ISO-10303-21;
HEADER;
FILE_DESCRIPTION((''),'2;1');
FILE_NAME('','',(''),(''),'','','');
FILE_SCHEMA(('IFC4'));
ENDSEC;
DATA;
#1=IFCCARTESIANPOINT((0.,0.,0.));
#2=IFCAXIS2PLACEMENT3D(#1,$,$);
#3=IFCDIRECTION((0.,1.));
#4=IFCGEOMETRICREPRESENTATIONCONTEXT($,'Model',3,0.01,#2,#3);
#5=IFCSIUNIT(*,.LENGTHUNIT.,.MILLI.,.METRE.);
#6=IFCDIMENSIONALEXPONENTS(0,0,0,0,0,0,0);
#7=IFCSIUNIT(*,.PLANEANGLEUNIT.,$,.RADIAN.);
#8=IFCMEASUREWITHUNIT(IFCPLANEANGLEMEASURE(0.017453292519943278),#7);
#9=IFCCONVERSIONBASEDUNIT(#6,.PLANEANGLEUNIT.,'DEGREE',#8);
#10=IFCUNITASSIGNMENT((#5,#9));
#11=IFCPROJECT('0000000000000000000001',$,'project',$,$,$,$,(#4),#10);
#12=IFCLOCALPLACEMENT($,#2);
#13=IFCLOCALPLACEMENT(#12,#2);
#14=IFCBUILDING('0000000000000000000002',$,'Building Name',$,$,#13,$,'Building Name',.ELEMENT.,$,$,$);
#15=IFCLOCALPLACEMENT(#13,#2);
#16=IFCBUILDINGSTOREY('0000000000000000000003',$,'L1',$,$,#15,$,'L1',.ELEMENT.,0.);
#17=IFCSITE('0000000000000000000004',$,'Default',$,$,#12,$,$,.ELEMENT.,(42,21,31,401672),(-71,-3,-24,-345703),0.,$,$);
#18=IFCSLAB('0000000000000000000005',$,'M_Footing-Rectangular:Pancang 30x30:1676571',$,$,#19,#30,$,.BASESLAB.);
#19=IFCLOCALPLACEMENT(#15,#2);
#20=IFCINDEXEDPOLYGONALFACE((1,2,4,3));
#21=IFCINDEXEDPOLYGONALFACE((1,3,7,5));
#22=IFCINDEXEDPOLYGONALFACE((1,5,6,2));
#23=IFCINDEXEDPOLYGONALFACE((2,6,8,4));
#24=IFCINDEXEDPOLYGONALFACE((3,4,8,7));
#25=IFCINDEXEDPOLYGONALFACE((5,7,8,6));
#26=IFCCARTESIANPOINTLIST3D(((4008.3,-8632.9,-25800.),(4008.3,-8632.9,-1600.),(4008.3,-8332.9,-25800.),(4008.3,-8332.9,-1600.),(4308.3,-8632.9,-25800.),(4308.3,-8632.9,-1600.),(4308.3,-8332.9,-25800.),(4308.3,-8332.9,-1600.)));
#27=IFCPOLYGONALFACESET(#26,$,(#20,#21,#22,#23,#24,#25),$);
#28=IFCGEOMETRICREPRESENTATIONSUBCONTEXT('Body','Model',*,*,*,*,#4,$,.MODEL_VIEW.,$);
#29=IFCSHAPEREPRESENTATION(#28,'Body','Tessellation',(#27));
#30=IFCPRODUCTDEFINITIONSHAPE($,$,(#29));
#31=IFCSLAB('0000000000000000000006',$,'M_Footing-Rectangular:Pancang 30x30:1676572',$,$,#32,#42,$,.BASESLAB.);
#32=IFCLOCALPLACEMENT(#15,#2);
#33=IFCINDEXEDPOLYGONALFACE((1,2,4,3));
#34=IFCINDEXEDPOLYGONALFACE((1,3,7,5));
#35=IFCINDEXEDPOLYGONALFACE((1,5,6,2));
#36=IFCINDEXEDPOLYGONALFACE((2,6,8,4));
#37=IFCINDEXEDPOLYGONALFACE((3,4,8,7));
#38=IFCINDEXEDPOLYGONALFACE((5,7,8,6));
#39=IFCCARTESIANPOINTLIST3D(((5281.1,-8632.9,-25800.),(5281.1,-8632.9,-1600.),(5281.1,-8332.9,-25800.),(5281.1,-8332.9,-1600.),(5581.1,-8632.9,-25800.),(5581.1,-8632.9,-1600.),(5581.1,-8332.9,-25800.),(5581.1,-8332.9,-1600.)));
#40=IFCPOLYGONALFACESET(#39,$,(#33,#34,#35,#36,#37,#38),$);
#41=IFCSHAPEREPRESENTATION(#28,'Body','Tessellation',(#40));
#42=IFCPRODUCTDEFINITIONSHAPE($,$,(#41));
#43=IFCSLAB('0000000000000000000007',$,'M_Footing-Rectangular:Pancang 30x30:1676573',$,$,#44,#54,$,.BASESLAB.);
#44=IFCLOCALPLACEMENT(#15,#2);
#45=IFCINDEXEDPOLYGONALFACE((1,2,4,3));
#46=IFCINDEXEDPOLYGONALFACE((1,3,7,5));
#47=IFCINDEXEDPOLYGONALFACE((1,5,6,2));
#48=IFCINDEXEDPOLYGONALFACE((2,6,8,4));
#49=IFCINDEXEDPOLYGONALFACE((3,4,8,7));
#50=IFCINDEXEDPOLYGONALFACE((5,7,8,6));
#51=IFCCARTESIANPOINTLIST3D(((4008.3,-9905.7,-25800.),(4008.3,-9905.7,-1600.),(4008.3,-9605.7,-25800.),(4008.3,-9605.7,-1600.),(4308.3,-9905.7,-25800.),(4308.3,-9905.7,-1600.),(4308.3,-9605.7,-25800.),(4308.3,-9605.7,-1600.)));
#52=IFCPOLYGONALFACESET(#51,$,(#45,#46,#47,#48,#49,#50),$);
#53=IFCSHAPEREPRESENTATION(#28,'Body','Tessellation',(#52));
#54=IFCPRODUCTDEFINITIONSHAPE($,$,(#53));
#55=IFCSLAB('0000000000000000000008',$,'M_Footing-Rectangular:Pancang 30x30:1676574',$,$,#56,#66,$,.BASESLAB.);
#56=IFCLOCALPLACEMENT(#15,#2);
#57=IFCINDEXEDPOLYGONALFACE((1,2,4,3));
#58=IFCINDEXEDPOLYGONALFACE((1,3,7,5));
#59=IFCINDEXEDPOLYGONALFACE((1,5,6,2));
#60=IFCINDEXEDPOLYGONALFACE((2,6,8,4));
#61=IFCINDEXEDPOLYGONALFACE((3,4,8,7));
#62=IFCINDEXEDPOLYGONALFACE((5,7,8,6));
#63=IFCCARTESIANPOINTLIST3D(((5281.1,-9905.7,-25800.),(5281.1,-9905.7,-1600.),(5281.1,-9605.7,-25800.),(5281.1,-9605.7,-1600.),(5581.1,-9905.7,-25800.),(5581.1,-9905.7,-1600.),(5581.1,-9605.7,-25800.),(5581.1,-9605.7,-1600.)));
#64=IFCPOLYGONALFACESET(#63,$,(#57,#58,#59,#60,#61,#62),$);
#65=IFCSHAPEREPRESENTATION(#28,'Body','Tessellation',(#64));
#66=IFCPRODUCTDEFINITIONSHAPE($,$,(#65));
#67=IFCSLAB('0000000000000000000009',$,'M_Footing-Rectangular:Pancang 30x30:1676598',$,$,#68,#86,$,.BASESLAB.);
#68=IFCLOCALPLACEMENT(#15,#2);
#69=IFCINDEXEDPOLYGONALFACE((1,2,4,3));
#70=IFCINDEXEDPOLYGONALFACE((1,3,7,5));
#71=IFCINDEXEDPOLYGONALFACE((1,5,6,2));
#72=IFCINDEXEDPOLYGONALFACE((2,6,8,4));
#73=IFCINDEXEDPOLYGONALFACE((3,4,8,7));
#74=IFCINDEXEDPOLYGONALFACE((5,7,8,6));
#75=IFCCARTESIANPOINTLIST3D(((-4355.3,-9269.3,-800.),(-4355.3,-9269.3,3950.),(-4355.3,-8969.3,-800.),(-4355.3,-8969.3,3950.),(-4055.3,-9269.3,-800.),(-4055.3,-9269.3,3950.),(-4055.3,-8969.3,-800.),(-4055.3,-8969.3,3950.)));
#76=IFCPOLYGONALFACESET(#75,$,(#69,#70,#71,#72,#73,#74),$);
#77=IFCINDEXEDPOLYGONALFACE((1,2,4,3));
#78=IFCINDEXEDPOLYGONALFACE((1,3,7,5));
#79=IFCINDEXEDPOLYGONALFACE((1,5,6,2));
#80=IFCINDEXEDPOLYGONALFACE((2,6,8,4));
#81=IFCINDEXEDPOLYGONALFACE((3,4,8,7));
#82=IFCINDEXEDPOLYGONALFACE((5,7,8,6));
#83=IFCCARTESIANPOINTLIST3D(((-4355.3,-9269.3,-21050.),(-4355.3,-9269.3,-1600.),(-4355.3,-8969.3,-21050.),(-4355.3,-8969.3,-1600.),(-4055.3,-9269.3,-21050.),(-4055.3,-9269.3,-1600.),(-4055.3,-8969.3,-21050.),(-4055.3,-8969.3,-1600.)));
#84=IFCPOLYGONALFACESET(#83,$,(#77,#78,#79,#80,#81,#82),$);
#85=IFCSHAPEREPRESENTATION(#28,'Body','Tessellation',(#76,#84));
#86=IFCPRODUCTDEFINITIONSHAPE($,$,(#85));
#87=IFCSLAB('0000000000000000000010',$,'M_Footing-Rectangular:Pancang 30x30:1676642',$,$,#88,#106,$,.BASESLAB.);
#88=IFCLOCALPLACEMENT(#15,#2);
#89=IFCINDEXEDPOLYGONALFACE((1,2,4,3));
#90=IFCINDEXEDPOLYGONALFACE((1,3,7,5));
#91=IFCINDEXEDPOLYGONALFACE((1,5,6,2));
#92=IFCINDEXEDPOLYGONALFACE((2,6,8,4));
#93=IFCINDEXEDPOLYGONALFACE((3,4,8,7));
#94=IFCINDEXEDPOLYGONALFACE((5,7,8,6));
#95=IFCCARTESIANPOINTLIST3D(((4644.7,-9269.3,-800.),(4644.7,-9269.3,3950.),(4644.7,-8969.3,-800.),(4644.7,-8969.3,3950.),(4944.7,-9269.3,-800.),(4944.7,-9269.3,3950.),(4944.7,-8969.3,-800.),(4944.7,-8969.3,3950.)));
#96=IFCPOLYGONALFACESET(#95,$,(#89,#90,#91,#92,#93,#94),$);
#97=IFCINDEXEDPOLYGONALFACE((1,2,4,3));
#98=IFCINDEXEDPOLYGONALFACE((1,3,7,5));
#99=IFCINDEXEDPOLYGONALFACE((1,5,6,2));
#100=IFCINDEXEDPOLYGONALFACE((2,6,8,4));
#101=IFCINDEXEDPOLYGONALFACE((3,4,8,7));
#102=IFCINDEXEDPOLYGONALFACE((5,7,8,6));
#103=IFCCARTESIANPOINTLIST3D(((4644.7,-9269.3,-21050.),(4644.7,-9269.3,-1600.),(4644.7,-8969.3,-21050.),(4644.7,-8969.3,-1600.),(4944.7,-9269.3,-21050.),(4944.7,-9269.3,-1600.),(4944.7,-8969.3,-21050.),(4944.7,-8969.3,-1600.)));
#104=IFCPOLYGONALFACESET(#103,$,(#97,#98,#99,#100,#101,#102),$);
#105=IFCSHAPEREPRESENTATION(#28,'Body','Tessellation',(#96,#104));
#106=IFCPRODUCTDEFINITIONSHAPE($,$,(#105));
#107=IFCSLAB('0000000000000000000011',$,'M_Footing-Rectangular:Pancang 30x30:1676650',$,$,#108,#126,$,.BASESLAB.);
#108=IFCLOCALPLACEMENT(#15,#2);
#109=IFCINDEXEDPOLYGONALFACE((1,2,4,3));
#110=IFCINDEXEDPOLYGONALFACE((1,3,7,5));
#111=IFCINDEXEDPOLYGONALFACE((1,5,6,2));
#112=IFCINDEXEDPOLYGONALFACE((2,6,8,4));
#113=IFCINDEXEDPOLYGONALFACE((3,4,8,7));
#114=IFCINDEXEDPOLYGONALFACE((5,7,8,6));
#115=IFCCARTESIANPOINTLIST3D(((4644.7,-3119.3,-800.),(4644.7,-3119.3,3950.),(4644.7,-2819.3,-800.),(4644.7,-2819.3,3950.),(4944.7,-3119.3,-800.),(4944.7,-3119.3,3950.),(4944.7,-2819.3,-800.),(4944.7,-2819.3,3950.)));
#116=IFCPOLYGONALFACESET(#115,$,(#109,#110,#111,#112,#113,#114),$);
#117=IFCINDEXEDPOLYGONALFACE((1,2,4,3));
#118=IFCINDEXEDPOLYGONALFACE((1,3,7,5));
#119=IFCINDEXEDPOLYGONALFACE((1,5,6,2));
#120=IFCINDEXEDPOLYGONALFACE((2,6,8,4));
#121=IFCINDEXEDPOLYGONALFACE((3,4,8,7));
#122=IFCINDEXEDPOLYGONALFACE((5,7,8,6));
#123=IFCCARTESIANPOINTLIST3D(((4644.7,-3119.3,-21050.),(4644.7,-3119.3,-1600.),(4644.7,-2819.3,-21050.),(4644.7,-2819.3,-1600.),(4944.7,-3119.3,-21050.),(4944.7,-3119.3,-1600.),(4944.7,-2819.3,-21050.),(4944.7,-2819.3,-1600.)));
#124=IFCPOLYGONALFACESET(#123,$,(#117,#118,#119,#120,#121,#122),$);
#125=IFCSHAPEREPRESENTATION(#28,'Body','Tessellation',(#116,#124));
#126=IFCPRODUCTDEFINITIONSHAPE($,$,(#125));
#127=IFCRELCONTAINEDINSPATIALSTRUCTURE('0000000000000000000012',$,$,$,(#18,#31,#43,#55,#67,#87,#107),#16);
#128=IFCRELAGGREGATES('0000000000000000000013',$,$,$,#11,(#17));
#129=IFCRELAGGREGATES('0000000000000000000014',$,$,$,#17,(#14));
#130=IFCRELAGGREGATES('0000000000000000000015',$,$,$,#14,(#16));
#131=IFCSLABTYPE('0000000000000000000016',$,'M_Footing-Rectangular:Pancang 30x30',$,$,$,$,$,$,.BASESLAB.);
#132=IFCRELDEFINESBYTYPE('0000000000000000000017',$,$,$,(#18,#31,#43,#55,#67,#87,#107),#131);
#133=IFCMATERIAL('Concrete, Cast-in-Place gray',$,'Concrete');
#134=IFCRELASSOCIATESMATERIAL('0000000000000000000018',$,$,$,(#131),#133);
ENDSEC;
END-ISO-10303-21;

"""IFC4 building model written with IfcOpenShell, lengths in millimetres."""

from ifc_helpers import new_model, entity, si_unit, converted_unit, direction, frame, origin, place, context, subcontext, project, spatial, indexed_curve, outline, extrude, material, type_object, element, save


model = new_model("IFC4")

# Units and contexts
model_context = context("Model", 3, precision=0.01, world=origin(), true_north=direction((0.0, 1.0)))
body_context = subcontext(model_context, "Body", "Model", "MODEL_VIEW")
ifc_project = project(units=[si_unit("LENGTHUNIT", "METRE", prefix="MILLI"), converted_unit("PLANEANGLEUNIT", "DEGREE", entity("IfcPlaneAngleMeasure", 0.017453292519943278), si_unit("PLANEANGLEUNIT", "RADIAN"), dimensions=[0, 0, 0, 0, 0, 0, 0])], contexts=[model_context])

# Site, building, storey
site_placement = place(None, origin())
site = spatial("IfcSite", under=ifc_project, at=site_placement, Name="Default", CompositionType="ELEMENT", RefLatitude=(42, 21, 31, 401672), RefLongitude=(-71, -3, -24, -345703), RefElevation=0.0)
building_placement = place(site_placement, origin())
building = spatial("IfcBuilding", under=site, at=building_placement, Name="Building Name", LongName="Building Name", CompositionType="ELEMENT")
storey_placement = place(building_placement, origin())
storey = spatial("IfcBuildingStorey", under=building, at=storey_placement, Name="L1", LongName="L1", CompositionType="ELEMENT", Elevation=0.0)

# Slabs
ifc_material = material(Name="Concrete, Cast-in-Place gray", Category="Concrete")
slab_type = type_object("IfcSlabType", Name="M_Footing-Rectangular:Pancang 30x30", PredefinedType="BASESLAB", material=ifc_material)
slab_1_placement = place(storey_placement, origin())
element("IfcSlab", 1, at=slab_1_placement, inside=storey, type_object=slab_type, Name="M_Footing-Rectangular:Pancang 30x30:1676571", PredefinedType="BASESLAB", context=body_context, shape_type="SweptSolid", body=[
    extrude(outline(indexed_curve([(-150.0, -150.0), (150.0, -150.0), (150.0, 150.0), (-150.0, 150.0), (-150.0, -150.0)], self_intersect=False)), frame((4158.3, -8482.9, -25800.0), z_axis=(0.0, 0.0, 1.0), x_axis=(-1.0, 0.0, 0.0)), (0.0, 0.0, 1.0), 24200.0),
])
slab_2_placement = place(storey_placement, origin())
element("IfcSlab", 2, at=slab_2_placement, inside=storey, type_object=slab_type, Name="M_Footing-Rectangular:Pancang 30x30:1676572", PredefinedType="BASESLAB", context=body_context, shape_type="SweptSolid", body=[
    extrude(outline(indexed_curve([(-150.0, -150.0), (150.0, -150.0), (150.0, 150.0), (-150.0, 150.0), (-150.0, -150.0)], self_intersect=False)), frame((5431.1, -8482.9, -25800.0), z_axis=(0.0, 0.0, 1.0), x_axis=(-1.0, 0.0, 0.0)), (0.0, 0.0, 1.0), 24200.0),
])
slab_3_placement = place(storey_placement, origin())
element("IfcSlab", 3, at=slab_3_placement, inside=storey, type_object=slab_type, Name="M_Footing-Rectangular:Pancang 30x30:1676573", PredefinedType="BASESLAB", context=body_context, shape_type="SweptSolid", body=[
    extrude(outline(indexed_curve([(-150.0, -150.0), (150.0, -150.0), (150.0, 150.0), (-150.0, 150.0), (-150.0, -150.0)], self_intersect=False)), frame((4158.3, -9755.7, -25800.0), z_axis=(0.0, 0.0, 1.0), x_axis=(-1.0, 0.0, 0.0)), (0.0, 0.0, 1.0), 24200.0),
])
slab_4_placement = place(storey_placement, origin())
element("IfcSlab", 4, at=slab_4_placement, inside=storey, type_object=slab_type, Name="M_Footing-Rectangular:Pancang 30x30:1676574", PredefinedType="BASESLAB", context=body_context, shape_type="SweptSolid", body=[
    extrude(outline(indexed_curve([(-150.0, -150.0), (150.0, -150.0), (150.0, 150.0), (-150.0, 150.0), (-150.0, -150.0)], self_intersect=False)), frame((5431.1, -9755.7, -25800.0), z_axis=(0.0, 0.0, 1.0), x_axis=(-1.0, 0.0, 0.0)), (0.0, 0.0, 1.0), 24200.0),
])
slab_5_placement = place(storey_placement, origin())
element("IfcSlab", 5, at=slab_5_placement, inside=storey, type_object=slab_type, Name="M_Footing-Rectangular:Pancang 30x30:1676598", PredefinedType="BASESLAB", context=body_context, shape_type="SweptSolid", body=[
    extrude(outline(indexed_curve([(-150.0, -150.0), (150.0, -150.0), (150.0, 150.0), (-150.0, 150.0), (-150.0, -150.0)], self_intersect=False)), frame((-4205.3, -9119.3, -800.0), z_axis=(0.0, 0.0, 1.0), x_axis=(0.0, -1.0, 0.0)), (0.0, 0.0, 1.0), 4750.0),
    extrude(outline(indexed_curve([(-150.0, -150.0), (150.0, -150.0), (150.0, 150.0), (-150.0, 150.0), (-150.0, -150.0)], self_intersect=False)), frame((-4205.3, -9119.3, -21050.0), z_axis=(0.0, 0.0, 1.0), x_axis=(-1.0, 0.0, 0.0)), (0.0, 0.0, 1.0), 19450.0),
])
slab_6_placement = place(storey_placement, origin())
element("IfcSlab", 6, at=slab_6_placement, inside=storey, type_object=slab_type, Name="M_Footing-Rectangular:Pancang 30x30:1676642", PredefinedType="BASESLAB", context=body_context, shape_type="SweptSolid", body=[
    extrude(outline(indexed_curve([(-150.0, -150.0), (150.0, -150.0), (150.0, 150.0), (-150.0, 150.0), (-150.0, -150.0)], self_intersect=False)), frame((4794.7, -9119.3, -800.0), z_axis=(0.0, 0.0, 1.0), x_axis=(0.0, -1.0, 0.0)), (0.0, 0.0, 1.0), 4750.0),
    extrude(outline(indexed_curve([(-150.0, -150.0), (150.0, -150.0), (150.0, 150.0), (-150.0, 150.0), (-150.0, -150.0)], self_intersect=False)), frame((4794.7, -9119.3, -21050.0), z_axis=(0.0, 0.0, 1.0), x_axis=(-1.0, 0.0, 0.0)), (0.0, 0.0, 1.0), 19450.0),
])
slab_7_placement = place(storey_placement, origin())
element("IfcSlab", 7, at=slab_7_placement, inside=storey, type_object=slab_type, Name="M_Footing-Rectangular:Pancang 30x30:1676650", PredefinedType="BASESLAB", context=body_context, shape_type="SweptSolid", body=[
    extrude(outline(indexed_curve([(-150.0, -150.0), (150.0, -150.0), (150.0, 150.0), (-150.0, 150.0), (-150.0, -150.0)], self_intersect=False)), frame((4794.7, -2969.3, -800.0), z_axis=(0.0, 0.0, 1.0), x_axis=(0.0, -1.0, 0.0)), (0.0, 0.0, 1.0), 4750.0),
    extrude(outline(indexed_curve([(-150.0, -150.0), (150.0, -150.0), (150.0, 150.0), (-150.0, 150.0), (-150.0, -150.0)], self_intersect=False)), frame((4794.7, -2969.3, -21050.0), z_axis=(0.0, 0.0, 1.0), x_axis=(-1.0, 0.0, 0.0)), (0.0, 0.0, 1.0), 19450.0),
])

save(model, "model.ifc")
